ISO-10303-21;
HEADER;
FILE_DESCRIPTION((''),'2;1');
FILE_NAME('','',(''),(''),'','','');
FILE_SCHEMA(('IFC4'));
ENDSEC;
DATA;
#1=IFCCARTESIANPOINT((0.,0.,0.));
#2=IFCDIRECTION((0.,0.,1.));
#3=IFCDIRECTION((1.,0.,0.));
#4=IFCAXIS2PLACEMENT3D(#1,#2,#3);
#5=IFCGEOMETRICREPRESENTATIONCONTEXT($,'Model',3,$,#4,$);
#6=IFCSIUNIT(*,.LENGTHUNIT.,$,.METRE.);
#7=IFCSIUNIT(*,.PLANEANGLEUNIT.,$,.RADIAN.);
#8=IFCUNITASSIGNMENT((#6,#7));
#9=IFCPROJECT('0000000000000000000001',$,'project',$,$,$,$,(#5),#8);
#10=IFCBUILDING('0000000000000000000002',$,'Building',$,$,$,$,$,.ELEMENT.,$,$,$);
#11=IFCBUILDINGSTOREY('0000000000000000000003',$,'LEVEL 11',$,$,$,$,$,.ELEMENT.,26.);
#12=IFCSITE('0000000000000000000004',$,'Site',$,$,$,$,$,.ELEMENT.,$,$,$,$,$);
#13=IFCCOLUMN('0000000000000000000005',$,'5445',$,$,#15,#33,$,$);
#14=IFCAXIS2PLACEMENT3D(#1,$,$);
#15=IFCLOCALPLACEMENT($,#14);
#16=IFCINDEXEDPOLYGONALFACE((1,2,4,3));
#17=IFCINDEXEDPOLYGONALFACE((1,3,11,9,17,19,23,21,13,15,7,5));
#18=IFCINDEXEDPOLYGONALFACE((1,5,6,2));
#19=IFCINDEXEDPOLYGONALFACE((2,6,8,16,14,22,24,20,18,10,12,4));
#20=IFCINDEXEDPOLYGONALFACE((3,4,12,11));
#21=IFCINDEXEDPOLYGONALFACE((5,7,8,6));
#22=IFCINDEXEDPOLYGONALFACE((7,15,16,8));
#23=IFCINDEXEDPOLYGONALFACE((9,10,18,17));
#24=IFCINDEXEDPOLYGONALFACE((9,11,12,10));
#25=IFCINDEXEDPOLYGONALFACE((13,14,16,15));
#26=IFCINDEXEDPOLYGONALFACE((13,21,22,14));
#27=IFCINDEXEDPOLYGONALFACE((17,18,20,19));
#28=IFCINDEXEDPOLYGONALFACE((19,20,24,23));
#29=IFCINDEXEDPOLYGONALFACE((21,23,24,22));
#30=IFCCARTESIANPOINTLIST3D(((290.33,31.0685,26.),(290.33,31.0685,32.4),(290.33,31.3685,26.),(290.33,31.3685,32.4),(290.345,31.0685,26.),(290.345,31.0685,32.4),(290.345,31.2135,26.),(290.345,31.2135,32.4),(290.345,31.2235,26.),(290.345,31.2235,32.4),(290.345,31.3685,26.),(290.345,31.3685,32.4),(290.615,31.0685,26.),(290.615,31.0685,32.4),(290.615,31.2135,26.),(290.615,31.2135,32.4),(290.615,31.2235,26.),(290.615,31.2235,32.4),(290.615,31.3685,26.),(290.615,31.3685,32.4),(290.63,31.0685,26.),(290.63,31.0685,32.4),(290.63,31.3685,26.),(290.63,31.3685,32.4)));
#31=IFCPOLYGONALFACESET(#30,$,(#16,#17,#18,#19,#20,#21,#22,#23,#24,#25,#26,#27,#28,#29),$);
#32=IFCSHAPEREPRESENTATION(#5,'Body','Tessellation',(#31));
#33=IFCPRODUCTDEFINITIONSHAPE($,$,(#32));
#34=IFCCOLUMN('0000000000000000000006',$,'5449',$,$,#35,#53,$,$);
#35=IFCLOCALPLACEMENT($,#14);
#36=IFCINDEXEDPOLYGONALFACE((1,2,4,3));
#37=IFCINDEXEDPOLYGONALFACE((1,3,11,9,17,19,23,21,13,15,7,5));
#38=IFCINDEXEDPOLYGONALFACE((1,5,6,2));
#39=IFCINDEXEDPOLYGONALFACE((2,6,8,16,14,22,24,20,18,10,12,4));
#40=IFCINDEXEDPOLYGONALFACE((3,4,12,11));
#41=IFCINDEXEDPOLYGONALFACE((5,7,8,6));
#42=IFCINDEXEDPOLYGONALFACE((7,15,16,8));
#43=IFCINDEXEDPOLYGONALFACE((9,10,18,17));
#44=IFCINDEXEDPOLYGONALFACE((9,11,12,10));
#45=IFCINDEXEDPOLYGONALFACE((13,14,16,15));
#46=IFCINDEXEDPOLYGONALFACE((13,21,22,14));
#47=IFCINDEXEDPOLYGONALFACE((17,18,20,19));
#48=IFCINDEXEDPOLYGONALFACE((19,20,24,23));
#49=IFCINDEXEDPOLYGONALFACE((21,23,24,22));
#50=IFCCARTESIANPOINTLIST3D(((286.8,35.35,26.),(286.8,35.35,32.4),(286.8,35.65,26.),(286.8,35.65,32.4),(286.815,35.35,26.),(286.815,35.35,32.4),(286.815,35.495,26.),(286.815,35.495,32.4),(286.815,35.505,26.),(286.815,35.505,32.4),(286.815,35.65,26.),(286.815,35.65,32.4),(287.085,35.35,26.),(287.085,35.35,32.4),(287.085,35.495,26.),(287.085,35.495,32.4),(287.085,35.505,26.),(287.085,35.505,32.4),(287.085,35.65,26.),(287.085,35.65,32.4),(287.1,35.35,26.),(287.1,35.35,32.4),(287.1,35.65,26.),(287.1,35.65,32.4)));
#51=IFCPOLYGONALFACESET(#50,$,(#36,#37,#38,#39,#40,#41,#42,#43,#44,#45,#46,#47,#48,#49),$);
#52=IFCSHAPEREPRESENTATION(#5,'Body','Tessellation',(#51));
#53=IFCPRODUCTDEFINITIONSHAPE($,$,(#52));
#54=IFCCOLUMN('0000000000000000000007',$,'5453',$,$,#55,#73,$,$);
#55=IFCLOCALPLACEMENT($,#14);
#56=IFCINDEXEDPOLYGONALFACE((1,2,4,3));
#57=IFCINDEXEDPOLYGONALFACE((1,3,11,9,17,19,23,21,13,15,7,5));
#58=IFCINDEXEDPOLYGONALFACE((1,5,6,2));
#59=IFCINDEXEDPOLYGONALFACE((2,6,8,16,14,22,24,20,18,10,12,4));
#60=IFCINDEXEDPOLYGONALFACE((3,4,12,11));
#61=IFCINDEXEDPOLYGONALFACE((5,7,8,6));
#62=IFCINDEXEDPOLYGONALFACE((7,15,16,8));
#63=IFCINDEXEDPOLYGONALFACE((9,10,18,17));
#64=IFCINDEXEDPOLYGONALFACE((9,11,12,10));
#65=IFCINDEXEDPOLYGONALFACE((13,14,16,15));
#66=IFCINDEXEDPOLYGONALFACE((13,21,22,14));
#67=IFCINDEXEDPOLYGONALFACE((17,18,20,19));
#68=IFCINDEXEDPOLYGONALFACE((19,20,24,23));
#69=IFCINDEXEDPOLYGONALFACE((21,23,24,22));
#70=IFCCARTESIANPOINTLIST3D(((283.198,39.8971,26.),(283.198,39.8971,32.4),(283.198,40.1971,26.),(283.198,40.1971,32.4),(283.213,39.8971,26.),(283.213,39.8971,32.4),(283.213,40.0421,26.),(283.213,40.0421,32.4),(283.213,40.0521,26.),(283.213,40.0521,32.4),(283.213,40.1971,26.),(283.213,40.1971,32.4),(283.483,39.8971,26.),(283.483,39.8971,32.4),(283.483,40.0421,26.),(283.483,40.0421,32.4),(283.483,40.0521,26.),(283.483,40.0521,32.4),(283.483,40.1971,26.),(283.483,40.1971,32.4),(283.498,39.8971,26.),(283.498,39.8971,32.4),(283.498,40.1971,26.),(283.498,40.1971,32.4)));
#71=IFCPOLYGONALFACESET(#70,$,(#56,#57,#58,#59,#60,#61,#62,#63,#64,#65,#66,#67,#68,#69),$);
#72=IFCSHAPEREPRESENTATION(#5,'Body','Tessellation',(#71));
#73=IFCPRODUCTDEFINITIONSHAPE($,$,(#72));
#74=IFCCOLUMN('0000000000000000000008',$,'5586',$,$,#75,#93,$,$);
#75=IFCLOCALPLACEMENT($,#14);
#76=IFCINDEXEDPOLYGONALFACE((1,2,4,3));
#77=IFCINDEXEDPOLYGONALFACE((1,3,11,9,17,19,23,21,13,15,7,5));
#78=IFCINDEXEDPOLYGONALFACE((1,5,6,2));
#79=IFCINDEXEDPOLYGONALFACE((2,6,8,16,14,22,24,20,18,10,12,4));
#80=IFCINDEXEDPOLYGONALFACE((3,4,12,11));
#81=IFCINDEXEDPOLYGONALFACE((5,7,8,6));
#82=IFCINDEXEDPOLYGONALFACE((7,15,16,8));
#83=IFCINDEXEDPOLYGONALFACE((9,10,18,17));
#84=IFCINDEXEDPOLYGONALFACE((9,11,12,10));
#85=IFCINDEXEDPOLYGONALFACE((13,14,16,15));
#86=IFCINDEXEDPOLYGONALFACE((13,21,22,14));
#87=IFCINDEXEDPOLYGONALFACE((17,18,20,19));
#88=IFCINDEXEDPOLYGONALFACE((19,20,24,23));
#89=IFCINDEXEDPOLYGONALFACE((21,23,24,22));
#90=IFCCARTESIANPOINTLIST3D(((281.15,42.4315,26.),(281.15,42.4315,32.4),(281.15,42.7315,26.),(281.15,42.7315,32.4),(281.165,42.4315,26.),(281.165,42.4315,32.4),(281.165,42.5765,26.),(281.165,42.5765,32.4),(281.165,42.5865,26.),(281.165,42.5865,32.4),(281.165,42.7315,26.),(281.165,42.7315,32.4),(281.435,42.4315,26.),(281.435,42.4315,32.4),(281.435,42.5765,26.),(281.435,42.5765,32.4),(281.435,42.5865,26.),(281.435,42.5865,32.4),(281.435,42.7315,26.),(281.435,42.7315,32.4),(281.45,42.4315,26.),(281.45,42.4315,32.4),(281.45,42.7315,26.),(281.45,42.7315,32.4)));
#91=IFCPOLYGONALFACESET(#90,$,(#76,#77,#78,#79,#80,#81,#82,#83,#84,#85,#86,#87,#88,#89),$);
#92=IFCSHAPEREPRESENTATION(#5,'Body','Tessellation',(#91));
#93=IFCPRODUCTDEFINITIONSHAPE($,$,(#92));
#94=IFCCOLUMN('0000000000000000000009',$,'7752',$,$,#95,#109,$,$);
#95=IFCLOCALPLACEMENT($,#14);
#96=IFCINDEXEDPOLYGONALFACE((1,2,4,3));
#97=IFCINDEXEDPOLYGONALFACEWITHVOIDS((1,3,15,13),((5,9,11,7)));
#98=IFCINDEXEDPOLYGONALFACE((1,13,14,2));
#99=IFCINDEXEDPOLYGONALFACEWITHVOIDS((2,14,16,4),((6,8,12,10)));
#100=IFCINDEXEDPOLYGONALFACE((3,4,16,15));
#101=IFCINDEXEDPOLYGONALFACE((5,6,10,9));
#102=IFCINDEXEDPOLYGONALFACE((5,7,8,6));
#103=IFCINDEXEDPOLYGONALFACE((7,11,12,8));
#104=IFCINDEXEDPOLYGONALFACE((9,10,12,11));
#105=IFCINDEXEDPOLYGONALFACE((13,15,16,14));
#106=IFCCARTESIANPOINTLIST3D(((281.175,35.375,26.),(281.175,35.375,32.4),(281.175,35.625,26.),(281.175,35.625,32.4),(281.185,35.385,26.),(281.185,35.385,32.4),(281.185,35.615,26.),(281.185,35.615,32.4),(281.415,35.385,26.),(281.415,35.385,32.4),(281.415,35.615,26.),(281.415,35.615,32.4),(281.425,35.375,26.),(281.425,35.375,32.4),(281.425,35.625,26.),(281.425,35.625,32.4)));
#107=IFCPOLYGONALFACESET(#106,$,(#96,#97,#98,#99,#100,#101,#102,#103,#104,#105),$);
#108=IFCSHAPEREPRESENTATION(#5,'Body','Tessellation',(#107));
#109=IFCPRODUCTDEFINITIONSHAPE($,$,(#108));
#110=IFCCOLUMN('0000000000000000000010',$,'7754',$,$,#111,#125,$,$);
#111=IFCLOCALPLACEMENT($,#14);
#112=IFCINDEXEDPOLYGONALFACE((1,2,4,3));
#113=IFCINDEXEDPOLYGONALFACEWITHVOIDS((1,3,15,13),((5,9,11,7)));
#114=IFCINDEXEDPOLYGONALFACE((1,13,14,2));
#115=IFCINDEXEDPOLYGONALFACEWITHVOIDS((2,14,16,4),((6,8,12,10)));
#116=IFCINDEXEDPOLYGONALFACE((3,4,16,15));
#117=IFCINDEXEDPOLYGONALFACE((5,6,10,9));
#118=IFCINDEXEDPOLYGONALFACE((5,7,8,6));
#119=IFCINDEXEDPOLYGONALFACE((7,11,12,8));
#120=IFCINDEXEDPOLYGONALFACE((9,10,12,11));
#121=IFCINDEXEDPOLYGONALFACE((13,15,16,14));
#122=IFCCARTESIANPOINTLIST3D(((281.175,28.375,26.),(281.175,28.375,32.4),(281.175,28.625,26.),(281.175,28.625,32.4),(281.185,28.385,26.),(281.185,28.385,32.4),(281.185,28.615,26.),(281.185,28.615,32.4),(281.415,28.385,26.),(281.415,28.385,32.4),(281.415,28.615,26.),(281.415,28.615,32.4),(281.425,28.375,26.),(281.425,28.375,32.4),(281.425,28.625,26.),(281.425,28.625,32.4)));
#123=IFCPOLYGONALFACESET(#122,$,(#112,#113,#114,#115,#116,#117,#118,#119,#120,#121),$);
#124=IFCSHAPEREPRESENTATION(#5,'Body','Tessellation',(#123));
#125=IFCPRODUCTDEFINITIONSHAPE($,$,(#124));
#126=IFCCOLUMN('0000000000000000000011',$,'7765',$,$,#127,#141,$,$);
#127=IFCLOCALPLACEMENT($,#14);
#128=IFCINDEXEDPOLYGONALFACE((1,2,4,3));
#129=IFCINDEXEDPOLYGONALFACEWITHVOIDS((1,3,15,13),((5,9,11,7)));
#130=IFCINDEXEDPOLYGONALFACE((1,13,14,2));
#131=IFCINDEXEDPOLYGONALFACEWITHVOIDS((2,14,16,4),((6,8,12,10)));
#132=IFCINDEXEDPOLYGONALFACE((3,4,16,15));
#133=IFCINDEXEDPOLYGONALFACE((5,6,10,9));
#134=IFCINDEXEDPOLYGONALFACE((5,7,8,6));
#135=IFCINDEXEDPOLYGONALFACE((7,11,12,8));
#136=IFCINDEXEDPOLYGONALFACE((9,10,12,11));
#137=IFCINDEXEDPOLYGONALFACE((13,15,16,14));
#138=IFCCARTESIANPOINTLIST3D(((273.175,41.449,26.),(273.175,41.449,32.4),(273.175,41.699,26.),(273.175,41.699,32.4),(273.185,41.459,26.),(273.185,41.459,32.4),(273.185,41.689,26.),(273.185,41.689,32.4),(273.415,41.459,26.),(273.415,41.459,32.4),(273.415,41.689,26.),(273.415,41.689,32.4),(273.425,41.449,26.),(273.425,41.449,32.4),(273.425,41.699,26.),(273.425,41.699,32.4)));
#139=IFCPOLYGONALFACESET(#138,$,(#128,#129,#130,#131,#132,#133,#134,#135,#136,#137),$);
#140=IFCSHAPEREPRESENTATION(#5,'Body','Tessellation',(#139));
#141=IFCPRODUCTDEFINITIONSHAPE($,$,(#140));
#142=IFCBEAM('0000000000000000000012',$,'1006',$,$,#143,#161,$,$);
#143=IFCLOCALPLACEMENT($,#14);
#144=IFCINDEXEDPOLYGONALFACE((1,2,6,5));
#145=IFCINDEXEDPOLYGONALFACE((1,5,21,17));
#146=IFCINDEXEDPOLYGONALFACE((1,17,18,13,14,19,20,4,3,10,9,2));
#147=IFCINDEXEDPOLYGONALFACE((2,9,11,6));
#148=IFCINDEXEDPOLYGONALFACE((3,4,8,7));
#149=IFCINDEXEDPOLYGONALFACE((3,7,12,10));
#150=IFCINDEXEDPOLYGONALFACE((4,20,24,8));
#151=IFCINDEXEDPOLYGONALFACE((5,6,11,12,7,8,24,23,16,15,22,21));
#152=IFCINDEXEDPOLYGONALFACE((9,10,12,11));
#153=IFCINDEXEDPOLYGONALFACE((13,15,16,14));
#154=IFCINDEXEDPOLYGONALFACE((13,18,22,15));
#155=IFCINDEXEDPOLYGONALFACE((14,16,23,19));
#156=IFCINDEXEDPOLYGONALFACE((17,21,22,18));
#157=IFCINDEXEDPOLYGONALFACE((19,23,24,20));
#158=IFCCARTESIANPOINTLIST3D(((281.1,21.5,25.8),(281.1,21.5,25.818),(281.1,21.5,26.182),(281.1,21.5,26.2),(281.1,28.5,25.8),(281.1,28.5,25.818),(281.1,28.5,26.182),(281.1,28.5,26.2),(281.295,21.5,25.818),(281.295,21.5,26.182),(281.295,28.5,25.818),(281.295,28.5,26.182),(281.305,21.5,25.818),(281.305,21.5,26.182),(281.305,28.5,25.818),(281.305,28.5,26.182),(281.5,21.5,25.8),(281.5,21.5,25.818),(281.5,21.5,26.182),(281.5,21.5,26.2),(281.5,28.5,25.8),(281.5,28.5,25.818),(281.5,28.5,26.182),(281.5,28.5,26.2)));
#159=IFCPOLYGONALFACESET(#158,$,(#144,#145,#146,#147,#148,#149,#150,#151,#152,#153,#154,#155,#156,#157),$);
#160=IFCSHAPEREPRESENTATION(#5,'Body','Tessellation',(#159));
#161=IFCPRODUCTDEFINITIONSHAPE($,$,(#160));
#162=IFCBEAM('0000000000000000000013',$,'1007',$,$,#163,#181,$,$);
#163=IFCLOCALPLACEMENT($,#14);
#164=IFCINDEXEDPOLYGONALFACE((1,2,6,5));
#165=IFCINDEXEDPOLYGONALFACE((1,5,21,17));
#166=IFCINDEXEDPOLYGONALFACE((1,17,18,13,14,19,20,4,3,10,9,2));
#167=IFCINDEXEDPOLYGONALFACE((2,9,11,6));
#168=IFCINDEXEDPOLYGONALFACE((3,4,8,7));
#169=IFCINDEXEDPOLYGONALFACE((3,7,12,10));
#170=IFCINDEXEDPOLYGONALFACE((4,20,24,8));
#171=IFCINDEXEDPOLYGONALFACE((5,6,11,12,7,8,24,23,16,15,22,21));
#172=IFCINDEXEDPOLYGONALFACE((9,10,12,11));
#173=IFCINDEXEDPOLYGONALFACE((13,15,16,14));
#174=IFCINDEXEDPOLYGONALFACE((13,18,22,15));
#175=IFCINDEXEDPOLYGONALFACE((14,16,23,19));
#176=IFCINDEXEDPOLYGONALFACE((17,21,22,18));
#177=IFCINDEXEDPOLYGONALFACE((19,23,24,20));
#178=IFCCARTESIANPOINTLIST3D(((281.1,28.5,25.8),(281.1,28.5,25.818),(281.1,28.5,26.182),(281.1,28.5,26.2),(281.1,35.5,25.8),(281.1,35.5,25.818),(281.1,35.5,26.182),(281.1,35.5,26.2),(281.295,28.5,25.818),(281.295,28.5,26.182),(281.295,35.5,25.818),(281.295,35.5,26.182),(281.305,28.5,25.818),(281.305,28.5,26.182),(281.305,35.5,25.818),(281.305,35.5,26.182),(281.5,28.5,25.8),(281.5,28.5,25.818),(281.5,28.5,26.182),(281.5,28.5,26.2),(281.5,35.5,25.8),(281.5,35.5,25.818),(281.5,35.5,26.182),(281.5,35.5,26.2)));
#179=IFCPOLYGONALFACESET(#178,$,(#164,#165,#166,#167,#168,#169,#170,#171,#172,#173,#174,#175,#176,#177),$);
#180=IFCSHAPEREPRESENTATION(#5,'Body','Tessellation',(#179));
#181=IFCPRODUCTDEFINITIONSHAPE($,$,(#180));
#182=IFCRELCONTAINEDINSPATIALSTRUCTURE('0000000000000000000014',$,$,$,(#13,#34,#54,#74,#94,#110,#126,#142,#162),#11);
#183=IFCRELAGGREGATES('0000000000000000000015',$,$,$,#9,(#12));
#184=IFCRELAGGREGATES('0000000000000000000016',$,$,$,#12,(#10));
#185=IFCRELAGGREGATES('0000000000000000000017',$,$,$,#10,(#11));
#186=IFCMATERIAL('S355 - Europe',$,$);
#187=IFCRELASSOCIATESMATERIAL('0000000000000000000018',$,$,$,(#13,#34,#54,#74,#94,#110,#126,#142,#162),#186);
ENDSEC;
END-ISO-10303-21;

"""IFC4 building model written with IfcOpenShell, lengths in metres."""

from ifc_helpers import new_model, si_unit, frame, origin_with_axes, origin_2d_with_axis, place, context, project, spatial, hollow_rectangle, i_section, extrude, material, material_profile, profile_set, profile_usage, element, save


model = new_model("IFC4")

# Units and contexts
model_context = context("Model", 3, world=origin_with_axes())
ifc_project = project(units=[si_unit("LENGTHUNIT", "METRE"), si_unit("PLANEANGLEUNIT", "RADIAN")], contexts=[model_context])

# Site, building, storey
site = spatial("IfcSite", under=ifc_project, Name="Site", CompositionType="ELEMENT")
building = spatial("IfcBuilding", under=site, Name="Building", CompositionType="ELEMENT")
storey = spatial("IfcBuildingStorey", under=building, Name="LEVEL 11", CompositionType="ELEMENT", Elevation=26.0)

# Columns
ifc_material = material(Name="S355 - Europe")
ifc_material_profile_1 = material_profile(ifc_material, i_section(OverallWidth=0.3, OverallDepth=0.3, WebThickness=0.01, FlangeThickness=0.015, at=origin_2d_with_axis()))
ifc_profile_set_1 = profile_set([ifc_material_profile_1])
ifc_profile_usage_1 = profile_usage(ifc_profile_set_1, cardinal=10)
column_1_placement = place(None, frame((290.48, 31.2185, 26.0), z_axis=(0.0, 0.0, 1.0), x_axis=(0.0, -1.0, 0.0)))
element("IfcColumn", 1, at=column_1_placement, inside=storey, material=ifc_profile_usage_1, Name="5445", context=model_context, shape_type="SweptSolid", body=[
    extrude(i_section(OverallWidth=0.3, OverallDepth=0.3, WebThickness=0.01, FlangeThickness=0.015, at=origin_2d_with_axis()), origin_with_axes(), (0.0, 0.0, 1.0), 6.4),
])
ifc_material_profile_2 = material_profile(ifc_material, i_section(OverallWidth=0.3, OverallDepth=0.3, WebThickness=0.01, FlangeThickness=0.015, at=origin_2d_with_axis()))
ifc_profile_set_2 = profile_set([ifc_material_profile_2])
ifc_profile_usage_2 = profile_usage(ifc_profile_set_2, cardinal=10)
column_2_placement = place(None, frame((286.95, 35.5, 26.0), z_axis=(0.0, 0.0, 1.0), x_axis=(0.0, -1.0, 0.0)))
element("IfcColumn", 2, at=column_2_placement, inside=storey, material=ifc_profile_usage_2, Name="5449", context=model_context, shape_type="SweptSolid", body=[
    extrude(i_section(OverallWidth=0.3, OverallDepth=0.3, WebThickness=0.01, FlangeThickness=0.015, at=origin_2d_with_axis()), origin_with_axes(), (0.0, 0.0, 1.0), 6.4),
])
ifc_material_profile_3 = material_profile(ifc_material, i_section(OverallWidth=0.3, OverallDepth=0.3, WebThickness=0.01, FlangeThickness=0.015, at=origin_2d_with_axis()))
ifc_profile_set_3 = profile_set([ifc_material_profile_3])
ifc_profile_usage_3 = profile_usage(ifc_profile_set_3, cardinal=10)
column_3_placement = place(None, frame((283.348, 40.0471, 26.0), z_axis=(0.0, 0.0, 1.0), x_axis=(0.0, -1.0, 0.0)))
element("IfcColumn", 3, at=column_3_placement, inside=storey, material=ifc_profile_usage_3, Name="5453", context=model_context, shape_type="SweptSolid", body=[
    extrude(i_section(OverallWidth=0.3, OverallDepth=0.3, WebThickness=0.01, FlangeThickness=0.015, at=origin_2d_with_axis()), origin_with_axes(), (0.0, 0.0, 1.0), 6.4),
])
ifc_material_profile_4 = material_profile(ifc_material, i_section(OverallWidth=0.3, OverallDepth=0.3, WebThickness=0.01, FlangeThickness=0.015, at=origin_2d_with_axis()))
ifc_profile_set_4 = profile_set([ifc_material_profile_4])
ifc_profile_usage_4 = profile_usage(ifc_profile_set_4, cardinal=10)
column_4_placement = place(None, frame((281.3, 42.5815, 26.0), z_axis=(0.0, 0.0, 1.0), x_axis=(0.0, -1.0, 0.0)))
element("IfcColumn", 4, at=column_4_placement, inside=storey, material=ifc_profile_usage_4, Name="5586", context=model_context, shape_type="SweptSolid", body=[
    extrude(i_section(OverallWidth=0.3, OverallDepth=0.3, WebThickness=0.01, FlangeThickness=0.015, at=origin_2d_with_axis()), origin_with_axes(), (0.0, 0.0, 1.0), 6.4),
])
ifc_material_profile_5 = material_profile(ifc_material, hollow_rectangle(XDim=0.25, YDim=0.25, WallThickness=0.01, at=origin_2d_with_axis()))
ifc_profile_set_5 = profile_set([ifc_material_profile_5])
ifc_profile_usage_5 = profile_usage(ifc_profile_set_5, cardinal=10)
column_5_placement = place(None, frame((281.3, 35.5, 26.0), z_axis=(0.0, 0.0, 1.0), x_axis=(0.0, -1.0, 0.0)))
element("IfcColumn", 5, at=column_5_placement, inside=storey, material=ifc_profile_usage_5, Name="7752", context=model_context, shape_type="SweptSolid", body=[
    extrude(hollow_rectangle(XDim=0.25, YDim=0.25, WallThickness=0.01, at=origin_2d_with_axis()), origin_with_axes(), (0.0, 0.0, 1.0), 6.4),
])
ifc_material_profile_6 = material_profile(ifc_material, hollow_rectangle(XDim=0.25, YDim=0.25, WallThickness=0.01, at=origin_2d_with_axis()))
ifc_profile_set_6 = profile_set([ifc_material_profile_6])
ifc_profile_usage_6 = profile_usage(ifc_profile_set_6, cardinal=10)
column_6_placement = place(None, frame((281.3, 28.5, 26.0), z_axis=(0.0, 0.0, 1.0), x_axis=(0.0, -1.0, 0.0)))
element("IfcColumn", 6, at=column_6_placement, inside=storey, material=ifc_profile_usage_6, Name="7754", context=model_context, shape_type="SweptSolid", body=[
    extrude(hollow_rectangle(XDim=0.25, YDim=0.25, WallThickness=0.01, at=origin_2d_with_axis()), origin_with_axes(), (0.0, 0.0, 1.0), 6.4),
])
ifc_material_profile_7 = material_profile(ifc_material, hollow_rectangle(XDim=0.25, YDim=0.25, WallThickness=0.01, at=origin_2d_with_axis()))
ifc_profile_set_7 = profile_set([ifc_material_profile_7])
ifc_profile_usage_7 = profile_usage(ifc_profile_set_7, cardinal=10)
column_7_placement = place(None, frame((273.3, 41.574, 26.0), z_axis=(0.0, 0.0, 1.0), x_axis=(0.0, -1.0, 0.0)))
element("IfcColumn", 7, at=column_7_placement, inside=storey, material=ifc_profile_usage_7, Name="7765", context=model_context, shape_type="SweptSolid", body=[
    extrude(hollow_rectangle(XDim=0.25, YDim=0.25, WallThickness=0.01, at=origin_2d_with_axis()), origin_with_axes(), (0.0, 0.0, 1.0), 6.4),
])

# Beams
ifc_material_profile_8 = material_profile(ifc_material, i_section(OverallWidth=0.4, OverallDepth=0.4, WebThickness=0.01, FlangeThickness=0.018, at=origin_2d_with_axis()))
ifc_profile_set_8 = profile_set([ifc_material_profile_8])
ifc_profile_usage_8 = profile_usage(ifc_profile_set_8, cardinal=10)
beam_1_placement = place(None, frame((281.3, 28.5, 26.0), z_axis=(0.0, -1.0, 0.0), x_axis=(1.0, 0.0, 0.0)))
element("IfcBeam", 8, at=beam_1_placement, inside=storey, material=ifc_profile_usage_8, Name="1006", context=model_context, shape_type="SweptSolid", body=[
    extrude(i_section(OverallWidth=0.4, OverallDepth=0.4, WebThickness=0.01, FlangeThickness=0.018, at=origin_2d_with_axis()), origin_with_axes(), (0.0, 0.0, 1.0), 7.0),
])
ifc_material_profile_9 = material_profile(ifc_material, i_section(OverallWidth=0.4, OverallDepth=0.4, WebThickness=0.01, FlangeThickness=0.018, at=origin_2d_with_axis()))
ifc_profile_set_9 = profile_set([ifc_material_profile_9])
ifc_profile_usage_9 = profile_usage(ifc_profile_set_9, cardinal=10)
beam_2_placement = place(None, frame((281.3, 35.5, 26.0), z_axis=(0.0, -1.0, 0.0), x_axis=(1.0, 0.0, 0.0)))
element("IfcBeam", 9, at=beam_2_placement, inside=storey, material=ifc_profile_usage_9, Name="1007", context=model_context, shape_type="SweptSolid", body=[
    extrude(i_section(OverallWidth=0.4, OverallDepth=0.4, WebThickness=0.01, FlangeThickness=0.018, at=origin_2d_with_axis()), origin_with_axes(), (0.0, 0.0, 1.0), 7.0),
])

save(model, "model.ifc")
